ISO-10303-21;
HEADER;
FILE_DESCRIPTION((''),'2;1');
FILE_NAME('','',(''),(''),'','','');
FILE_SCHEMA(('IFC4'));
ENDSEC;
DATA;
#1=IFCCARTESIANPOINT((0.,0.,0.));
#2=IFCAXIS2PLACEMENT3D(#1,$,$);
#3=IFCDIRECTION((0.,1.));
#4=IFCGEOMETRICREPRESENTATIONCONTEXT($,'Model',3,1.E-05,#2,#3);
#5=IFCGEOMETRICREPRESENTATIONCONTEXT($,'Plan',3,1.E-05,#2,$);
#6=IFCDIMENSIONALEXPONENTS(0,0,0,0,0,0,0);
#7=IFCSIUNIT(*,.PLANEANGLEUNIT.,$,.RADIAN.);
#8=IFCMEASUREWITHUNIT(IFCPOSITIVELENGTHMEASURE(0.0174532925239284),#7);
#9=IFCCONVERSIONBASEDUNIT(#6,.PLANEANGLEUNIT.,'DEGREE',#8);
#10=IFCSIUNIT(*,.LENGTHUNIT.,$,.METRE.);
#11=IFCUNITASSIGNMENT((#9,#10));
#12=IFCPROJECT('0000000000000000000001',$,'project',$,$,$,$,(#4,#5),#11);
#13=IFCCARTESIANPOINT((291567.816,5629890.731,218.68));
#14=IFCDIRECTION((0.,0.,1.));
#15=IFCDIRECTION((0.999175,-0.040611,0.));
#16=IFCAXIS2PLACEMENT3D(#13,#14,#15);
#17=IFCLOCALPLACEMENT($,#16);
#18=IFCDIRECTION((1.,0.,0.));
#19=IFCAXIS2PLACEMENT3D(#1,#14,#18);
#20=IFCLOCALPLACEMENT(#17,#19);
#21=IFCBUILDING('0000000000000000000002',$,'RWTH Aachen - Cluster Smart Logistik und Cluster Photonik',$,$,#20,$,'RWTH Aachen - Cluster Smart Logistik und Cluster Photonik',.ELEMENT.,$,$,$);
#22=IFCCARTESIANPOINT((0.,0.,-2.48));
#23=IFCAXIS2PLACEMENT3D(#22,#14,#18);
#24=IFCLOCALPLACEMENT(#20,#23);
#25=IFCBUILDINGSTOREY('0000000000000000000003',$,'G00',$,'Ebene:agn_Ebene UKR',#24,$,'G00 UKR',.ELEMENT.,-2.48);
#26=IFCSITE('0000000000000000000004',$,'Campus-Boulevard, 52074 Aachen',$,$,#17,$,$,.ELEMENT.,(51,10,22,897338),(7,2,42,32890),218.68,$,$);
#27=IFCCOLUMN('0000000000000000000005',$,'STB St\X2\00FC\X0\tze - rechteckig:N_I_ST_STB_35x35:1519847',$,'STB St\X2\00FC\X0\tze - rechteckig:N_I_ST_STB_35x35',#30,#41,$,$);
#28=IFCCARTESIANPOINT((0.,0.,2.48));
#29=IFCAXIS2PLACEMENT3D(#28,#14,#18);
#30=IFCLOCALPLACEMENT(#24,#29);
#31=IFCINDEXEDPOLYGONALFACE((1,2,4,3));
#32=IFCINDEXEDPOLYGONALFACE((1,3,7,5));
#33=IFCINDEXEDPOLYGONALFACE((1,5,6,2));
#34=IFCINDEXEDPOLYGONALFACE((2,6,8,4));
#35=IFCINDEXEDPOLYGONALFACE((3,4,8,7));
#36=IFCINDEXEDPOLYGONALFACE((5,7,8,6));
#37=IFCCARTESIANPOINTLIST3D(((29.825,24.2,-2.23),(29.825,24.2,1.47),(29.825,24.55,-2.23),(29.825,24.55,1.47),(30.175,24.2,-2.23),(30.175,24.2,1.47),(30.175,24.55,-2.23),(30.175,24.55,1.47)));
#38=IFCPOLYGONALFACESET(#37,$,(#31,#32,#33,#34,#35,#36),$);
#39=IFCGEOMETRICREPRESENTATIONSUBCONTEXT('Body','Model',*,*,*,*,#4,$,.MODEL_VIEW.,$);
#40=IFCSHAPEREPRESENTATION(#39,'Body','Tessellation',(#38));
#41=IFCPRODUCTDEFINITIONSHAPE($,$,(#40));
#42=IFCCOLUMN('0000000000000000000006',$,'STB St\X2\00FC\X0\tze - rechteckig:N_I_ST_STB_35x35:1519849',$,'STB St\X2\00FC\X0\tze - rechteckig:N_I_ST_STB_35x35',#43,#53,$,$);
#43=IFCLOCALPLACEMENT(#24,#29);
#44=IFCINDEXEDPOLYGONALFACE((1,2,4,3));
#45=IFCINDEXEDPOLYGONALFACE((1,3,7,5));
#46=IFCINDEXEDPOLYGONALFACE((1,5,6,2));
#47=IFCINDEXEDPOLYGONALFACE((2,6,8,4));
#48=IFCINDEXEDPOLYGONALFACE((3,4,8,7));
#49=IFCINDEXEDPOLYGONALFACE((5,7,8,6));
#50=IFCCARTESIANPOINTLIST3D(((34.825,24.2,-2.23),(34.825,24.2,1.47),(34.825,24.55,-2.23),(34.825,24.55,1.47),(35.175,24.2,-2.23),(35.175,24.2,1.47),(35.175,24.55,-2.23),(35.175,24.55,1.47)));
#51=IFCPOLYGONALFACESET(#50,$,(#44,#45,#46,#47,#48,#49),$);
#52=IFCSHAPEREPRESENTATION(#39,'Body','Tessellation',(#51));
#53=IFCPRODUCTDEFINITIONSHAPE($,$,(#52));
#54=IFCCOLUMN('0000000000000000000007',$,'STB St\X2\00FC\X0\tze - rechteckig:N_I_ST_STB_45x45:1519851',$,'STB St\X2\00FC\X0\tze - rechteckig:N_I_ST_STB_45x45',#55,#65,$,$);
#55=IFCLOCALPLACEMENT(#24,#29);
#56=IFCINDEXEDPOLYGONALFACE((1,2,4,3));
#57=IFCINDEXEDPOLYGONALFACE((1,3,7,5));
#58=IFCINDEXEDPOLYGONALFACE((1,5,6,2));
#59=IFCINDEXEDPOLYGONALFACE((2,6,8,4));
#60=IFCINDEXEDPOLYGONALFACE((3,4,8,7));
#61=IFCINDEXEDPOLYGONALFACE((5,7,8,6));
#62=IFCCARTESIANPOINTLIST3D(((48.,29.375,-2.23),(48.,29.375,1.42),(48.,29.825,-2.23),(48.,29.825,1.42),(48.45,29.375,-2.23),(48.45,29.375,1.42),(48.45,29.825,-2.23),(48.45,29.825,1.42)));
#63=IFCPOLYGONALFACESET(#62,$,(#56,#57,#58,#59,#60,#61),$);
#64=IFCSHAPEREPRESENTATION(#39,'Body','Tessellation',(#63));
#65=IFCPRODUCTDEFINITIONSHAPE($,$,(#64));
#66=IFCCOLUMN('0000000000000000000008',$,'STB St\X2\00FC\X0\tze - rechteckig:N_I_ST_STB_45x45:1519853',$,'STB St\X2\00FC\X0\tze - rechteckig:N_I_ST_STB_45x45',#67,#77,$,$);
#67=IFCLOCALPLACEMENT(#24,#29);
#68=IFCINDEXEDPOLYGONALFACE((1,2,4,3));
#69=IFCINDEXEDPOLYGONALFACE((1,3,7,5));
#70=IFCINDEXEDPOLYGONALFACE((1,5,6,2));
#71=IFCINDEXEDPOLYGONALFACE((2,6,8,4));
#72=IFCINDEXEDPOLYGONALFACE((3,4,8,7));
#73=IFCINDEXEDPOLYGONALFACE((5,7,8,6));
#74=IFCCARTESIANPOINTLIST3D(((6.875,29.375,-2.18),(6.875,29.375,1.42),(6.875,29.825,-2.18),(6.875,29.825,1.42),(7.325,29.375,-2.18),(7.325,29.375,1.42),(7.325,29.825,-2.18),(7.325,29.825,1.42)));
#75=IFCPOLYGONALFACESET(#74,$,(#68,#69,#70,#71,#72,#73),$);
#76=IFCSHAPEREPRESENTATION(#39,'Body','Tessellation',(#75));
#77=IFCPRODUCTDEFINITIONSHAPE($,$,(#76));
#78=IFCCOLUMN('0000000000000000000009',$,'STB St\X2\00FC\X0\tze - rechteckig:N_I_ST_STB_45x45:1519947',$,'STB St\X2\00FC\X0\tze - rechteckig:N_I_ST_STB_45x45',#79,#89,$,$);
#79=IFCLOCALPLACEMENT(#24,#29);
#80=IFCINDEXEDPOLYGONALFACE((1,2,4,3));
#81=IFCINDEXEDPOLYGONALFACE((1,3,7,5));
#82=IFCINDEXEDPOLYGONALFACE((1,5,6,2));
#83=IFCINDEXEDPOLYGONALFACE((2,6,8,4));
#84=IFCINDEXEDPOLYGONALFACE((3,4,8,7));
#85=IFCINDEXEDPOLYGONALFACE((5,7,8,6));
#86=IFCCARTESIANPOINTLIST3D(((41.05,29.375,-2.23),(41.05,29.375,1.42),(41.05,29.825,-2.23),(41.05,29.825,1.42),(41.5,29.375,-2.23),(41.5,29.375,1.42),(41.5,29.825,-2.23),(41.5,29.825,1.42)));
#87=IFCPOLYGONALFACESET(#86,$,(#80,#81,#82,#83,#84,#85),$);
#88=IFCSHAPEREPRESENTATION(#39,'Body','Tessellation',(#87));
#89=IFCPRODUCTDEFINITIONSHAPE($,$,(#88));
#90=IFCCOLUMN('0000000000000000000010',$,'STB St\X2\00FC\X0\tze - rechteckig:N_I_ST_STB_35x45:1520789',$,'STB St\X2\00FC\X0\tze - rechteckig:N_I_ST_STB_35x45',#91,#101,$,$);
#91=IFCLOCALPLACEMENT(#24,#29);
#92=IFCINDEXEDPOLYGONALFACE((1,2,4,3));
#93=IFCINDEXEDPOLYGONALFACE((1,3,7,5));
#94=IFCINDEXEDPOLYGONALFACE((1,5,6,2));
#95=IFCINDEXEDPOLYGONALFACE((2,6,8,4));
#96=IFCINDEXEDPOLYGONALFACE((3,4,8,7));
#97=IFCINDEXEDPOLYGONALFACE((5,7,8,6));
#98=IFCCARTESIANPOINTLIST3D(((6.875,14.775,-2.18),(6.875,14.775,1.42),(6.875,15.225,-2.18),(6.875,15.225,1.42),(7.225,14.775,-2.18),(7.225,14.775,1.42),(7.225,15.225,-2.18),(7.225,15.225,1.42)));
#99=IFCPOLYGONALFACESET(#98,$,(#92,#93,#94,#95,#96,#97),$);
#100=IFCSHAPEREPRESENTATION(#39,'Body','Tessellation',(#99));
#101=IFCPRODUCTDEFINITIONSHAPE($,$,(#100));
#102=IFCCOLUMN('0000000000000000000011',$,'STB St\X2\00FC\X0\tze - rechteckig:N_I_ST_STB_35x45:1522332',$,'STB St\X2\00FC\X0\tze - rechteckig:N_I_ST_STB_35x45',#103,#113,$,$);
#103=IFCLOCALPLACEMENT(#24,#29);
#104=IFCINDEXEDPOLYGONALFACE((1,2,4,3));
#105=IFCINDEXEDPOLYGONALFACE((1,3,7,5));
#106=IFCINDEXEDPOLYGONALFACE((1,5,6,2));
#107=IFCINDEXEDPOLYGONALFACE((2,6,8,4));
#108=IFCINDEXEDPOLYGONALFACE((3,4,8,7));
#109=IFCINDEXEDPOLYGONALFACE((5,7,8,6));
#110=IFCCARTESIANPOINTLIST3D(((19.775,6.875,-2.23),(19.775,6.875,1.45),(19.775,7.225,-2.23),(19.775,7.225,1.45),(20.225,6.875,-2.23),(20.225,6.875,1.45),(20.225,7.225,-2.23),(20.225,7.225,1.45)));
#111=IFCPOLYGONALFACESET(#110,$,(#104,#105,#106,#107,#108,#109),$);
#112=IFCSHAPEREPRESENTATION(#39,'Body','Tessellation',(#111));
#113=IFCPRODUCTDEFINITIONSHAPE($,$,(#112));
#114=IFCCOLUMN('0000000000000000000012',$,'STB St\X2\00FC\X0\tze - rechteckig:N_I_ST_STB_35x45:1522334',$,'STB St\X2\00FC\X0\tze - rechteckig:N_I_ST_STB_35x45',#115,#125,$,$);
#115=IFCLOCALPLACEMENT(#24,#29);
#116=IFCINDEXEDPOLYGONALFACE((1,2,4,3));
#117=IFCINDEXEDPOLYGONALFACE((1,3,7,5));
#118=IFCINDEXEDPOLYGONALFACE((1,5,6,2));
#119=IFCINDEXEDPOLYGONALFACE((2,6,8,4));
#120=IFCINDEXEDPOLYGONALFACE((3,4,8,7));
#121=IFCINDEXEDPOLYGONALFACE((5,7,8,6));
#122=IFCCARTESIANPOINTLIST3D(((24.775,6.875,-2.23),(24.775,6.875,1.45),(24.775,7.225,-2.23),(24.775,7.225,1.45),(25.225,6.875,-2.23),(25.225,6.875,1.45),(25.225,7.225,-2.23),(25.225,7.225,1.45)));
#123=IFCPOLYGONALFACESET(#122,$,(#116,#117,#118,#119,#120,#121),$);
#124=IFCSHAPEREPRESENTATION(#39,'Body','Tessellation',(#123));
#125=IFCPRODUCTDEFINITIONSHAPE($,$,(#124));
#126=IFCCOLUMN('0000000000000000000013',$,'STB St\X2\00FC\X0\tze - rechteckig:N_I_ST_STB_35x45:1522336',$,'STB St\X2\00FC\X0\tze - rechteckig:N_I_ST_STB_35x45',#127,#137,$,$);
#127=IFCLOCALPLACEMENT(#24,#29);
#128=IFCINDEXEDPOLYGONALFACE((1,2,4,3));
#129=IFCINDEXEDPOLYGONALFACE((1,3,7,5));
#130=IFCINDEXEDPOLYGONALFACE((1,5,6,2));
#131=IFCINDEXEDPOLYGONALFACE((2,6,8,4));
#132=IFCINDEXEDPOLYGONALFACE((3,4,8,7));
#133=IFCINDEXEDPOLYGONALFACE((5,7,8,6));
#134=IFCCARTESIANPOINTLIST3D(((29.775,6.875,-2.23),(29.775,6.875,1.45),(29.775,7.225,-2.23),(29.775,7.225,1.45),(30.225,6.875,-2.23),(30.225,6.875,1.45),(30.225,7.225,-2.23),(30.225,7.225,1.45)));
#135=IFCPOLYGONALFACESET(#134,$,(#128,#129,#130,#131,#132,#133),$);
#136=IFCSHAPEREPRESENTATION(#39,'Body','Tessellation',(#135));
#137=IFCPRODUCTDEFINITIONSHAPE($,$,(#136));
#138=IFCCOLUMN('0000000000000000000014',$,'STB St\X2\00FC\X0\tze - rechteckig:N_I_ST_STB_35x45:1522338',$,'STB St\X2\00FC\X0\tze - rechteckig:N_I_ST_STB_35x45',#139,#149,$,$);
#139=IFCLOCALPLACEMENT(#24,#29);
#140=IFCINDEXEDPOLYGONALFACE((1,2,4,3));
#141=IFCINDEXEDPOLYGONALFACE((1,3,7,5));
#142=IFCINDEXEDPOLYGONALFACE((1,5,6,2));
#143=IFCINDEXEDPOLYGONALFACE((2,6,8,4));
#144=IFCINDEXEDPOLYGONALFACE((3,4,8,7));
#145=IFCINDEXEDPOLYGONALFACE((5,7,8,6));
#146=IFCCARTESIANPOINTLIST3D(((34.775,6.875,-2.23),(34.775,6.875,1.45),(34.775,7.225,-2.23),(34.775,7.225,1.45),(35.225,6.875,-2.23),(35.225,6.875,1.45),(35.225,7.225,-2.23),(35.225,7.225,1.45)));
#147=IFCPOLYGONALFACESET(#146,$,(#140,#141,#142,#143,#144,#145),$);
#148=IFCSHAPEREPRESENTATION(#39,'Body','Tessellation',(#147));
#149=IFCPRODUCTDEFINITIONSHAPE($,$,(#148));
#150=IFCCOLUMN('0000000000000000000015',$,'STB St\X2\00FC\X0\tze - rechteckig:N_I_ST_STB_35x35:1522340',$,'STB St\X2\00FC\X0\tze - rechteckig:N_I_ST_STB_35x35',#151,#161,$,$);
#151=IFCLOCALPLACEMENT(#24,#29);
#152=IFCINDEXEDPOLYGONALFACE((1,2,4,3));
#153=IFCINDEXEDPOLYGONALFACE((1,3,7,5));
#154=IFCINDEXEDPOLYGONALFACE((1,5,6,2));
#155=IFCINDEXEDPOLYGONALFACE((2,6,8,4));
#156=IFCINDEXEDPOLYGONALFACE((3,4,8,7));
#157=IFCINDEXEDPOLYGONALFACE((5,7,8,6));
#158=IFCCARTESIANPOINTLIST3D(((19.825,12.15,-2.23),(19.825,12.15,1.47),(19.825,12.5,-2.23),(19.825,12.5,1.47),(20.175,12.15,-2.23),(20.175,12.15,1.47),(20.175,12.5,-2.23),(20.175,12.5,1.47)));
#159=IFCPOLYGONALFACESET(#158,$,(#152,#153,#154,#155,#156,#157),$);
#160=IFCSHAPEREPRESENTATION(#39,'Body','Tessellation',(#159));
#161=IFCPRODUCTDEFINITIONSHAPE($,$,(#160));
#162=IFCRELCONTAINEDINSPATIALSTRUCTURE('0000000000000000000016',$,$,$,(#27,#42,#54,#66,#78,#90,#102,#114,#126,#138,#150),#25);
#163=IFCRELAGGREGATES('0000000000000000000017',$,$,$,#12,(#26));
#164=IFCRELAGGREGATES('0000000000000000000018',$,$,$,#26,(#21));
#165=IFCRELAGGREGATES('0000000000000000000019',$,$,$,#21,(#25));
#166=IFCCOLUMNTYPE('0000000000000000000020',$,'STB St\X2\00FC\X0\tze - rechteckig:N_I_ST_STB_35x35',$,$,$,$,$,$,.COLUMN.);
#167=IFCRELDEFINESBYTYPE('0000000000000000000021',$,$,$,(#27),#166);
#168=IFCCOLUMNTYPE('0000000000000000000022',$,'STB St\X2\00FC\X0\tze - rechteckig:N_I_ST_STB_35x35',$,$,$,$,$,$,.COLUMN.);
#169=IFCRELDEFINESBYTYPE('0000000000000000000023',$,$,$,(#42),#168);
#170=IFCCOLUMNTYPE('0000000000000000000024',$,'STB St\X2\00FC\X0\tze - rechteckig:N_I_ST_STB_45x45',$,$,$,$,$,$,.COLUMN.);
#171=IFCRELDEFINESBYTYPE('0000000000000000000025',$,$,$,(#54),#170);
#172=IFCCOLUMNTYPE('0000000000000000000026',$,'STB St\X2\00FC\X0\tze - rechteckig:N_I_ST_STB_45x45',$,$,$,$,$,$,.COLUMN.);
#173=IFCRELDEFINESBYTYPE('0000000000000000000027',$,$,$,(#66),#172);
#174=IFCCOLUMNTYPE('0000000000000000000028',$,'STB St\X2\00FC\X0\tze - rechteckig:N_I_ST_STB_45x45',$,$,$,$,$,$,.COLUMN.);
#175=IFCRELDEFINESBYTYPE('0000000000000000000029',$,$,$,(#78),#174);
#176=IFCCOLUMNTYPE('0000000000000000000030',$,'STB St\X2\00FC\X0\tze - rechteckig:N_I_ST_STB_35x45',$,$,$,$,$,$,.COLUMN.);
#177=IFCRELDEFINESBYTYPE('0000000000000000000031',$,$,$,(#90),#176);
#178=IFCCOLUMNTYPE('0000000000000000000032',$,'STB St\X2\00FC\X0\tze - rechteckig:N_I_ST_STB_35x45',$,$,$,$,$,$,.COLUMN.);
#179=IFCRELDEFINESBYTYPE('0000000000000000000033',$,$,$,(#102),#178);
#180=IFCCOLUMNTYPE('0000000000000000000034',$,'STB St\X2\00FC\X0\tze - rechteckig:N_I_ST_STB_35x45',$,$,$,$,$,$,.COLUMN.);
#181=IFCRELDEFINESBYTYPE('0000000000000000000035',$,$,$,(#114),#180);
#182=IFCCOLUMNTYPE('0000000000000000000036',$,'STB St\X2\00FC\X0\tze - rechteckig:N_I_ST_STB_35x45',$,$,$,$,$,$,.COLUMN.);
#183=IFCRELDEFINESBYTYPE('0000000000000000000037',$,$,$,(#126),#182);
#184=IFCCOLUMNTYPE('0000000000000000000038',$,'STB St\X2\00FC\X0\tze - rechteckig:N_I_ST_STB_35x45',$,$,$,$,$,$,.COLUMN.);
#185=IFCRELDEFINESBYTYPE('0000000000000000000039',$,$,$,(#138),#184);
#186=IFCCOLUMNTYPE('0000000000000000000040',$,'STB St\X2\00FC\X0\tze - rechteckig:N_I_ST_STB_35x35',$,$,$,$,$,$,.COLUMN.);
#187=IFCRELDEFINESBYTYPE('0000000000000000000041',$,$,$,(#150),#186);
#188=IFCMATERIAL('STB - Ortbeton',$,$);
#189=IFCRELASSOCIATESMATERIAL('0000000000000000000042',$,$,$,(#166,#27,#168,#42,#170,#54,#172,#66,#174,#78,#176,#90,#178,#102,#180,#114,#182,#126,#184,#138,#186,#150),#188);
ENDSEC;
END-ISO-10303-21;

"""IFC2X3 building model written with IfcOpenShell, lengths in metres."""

from ifc_helpers import new_model, entity, si_unit, converted_unit, direction, frame, frame_2d, origin, origin_with_axes, origin_2d_with_axis, place, context, subcontext, project, spatial, rectangle, extrude, source, transform, mapped, material, type_object, element, save


model = new_model("IFC2X3")

# Units and contexts
model_context = context("Model", 3, precision=1e-05, world=origin(), true_north=direction((0.0, 1.0)))
plan_context = context("Plan", 3, precision=1e-05, world=origin())
body_context = subcontext(model_context, "Body", "Model", "MODEL_VIEW")
ifc_project = project(units=[converted_unit("PLANEANGLEUNIT", "DEGREE", entity("IfcPositiveLengthMeasure", 0.0174532925239284), si_unit("PLANEANGLEUNIT", "RADIAN"), dimensions=[0, 0, 0, 0, 0, 0, 0]), si_unit("LENGTHUNIT", "METRE")], contexts=[model_context, plan_context])

# Site, building, storey
site_placement = place(None, frame((291567.816, 5629890.731, 218.68), z_axis=(0.0, 0.0, 1.0), x_axis=(0.999175, -0.040611, 0.0)))
site = spatial("IfcSite", under=ifc_project, at=site_placement, Name="Campus-Boulevard, 52074 Aachen", CompositionType="ELEMENT", RefLatitude=(51, 10, 22, 897338), RefLongitude=(7, 2, 42, 32890), RefElevation=218.68)
building_placement = place(site_placement, origin_with_axes())
building = spatial("IfcBuilding", under=site, at=building_placement, Name="RWTH Aachen - Cluster Smart Logistik und Cluster Photonik", LongName="RWTH Aachen - Cluster Smart Logistik und Cluster Photonik", CompositionType="ELEMENT")
storey_placement = place(building_placement, frame((0.0, 0.0, -2.48), z_axis=(0.0, 0.0, 1.0), x_axis=(1.0, 0.0, 0.0)))
storey = spatial("IfcBuildingStorey", under=building, at=storey_placement, Name="G00", ObjectType="Ebene:agn_Ebene UKR", LongName="G00 UKR", CompositionType="ELEMENT", Elevation=-2.48)

# Shared definitions
ifc_material = material(Name="STB - Ortbeton")

# Columns
column_type_1 = type_object("IfcColumnType", Name="STB Stütze - rechteckig:N_I_ST_STB_35x35", PredefinedType="COLUMN", material=ifc_material)
shared_shape_1 = source(origin(), body_context, "Body", "SweptSolid", [
    extrude(rectangle(XDim=0.35, YDim=0.35, at=origin_2d_with_axis()), frame((30.0, 24.375, -2.23), z_axis=(0.0, 0.0, 1.0), x_axis=(0.0, -1.0, 0.0)), (0.0, 0.0, 1.0), 3.7),
])
column_1_placement = place(storey_placement, frame((0.0, 0.0, 2.48), z_axis=(0.0, 0.0, 1.0), x_axis=(1.0, 0.0, 0.0)))
element("IfcColumn", 1, at=column_1_placement, inside=storey, type_object=column_type_1, material=ifc_material, Name="STB Stütze - rechteckig:N_I_ST_STB_35x35:1519847", ObjectType="STB Stütze - rechteckig:N_I_ST_STB_35x35", context=body_context, shape_type="MappedRepresentation", body=[
    mapped(shared_shape_1, transform((0.0, 0.0, 0.0), scale=1.0)),
])
column_type_2 = type_object("IfcColumnType", Name="STB Stütze - rechteckig:N_I_ST_STB_35x35", PredefinedType="COLUMN", material=ifc_material)
shared_shape_2 = source(origin(), body_context, "Body", "SweptSolid", [
    extrude(rectangle(XDim=0.35, YDim=0.35, at=origin_2d_with_axis()), frame((35.0, 24.375, -2.23), z_axis=(0.0, 0.0, 1.0), x_axis=(0.0, -1.0, 0.0)), (0.0, 0.0, 1.0), 3.7),
])
column_2_placement = place(storey_placement, frame((0.0, 0.0, 2.48), z_axis=(0.0, 0.0, 1.0), x_axis=(1.0, 0.0, 0.0)))
element("IfcColumn", 2, at=column_2_placement, inside=storey, type_object=column_type_2, material=ifc_material, Name="STB Stütze - rechteckig:N_I_ST_STB_35x35:1519849", ObjectType="STB Stütze - rechteckig:N_I_ST_STB_35x35", context=body_context, shape_type="MappedRepresentation", body=[
    mapped(shared_shape_2, transform((0.0, 0.0, 0.0), scale=1.0)),
])
column_type_3 = type_object("IfcColumnType", Name="STB Stütze - rechteckig:N_I_ST_STB_45x45", PredefinedType="COLUMN", material=ifc_material)
shared_shape_3 = source(origin(), body_context, "Body", "SweptSolid", [
    extrude(rectangle(XDim=0.45, YDim=0.45, at=origin_2d_with_axis()), frame((48.225, 29.6, -2.23), z_axis=(0.0, 0.0, 1.0), x_axis=(0.0, -1.0, 0.0)), (0.0, 0.0, 1.0), 3.65),
])
column_3_placement = place(storey_placement, frame((0.0, 0.0, 2.48), z_axis=(0.0, 0.0, 1.0), x_axis=(1.0, 0.0, 0.0)))
element("IfcColumn", 3, at=column_3_placement, inside=storey, type_object=column_type_3, material=ifc_material, Name="STB Stütze - rechteckig:N_I_ST_STB_45x45:1519851", ObjectType="STB Stütze - rechteckig:N_I_ST_STB_45x45", context=body_context, shape_type="MappedRepresentation", body=[
    mapped(shared_shape_3, transform((0.0, 0.0, 0.0), scale=1.0)),
])
column_type_4 = type_object("IfcColumnType", Name="STB Stütze - rechteckig:N_I_ST_STB_45x45", PredefinedType="COLUMN", material=ifc_material)
shared_shape_4 = source(origin(), body_context, "Body", "SweptSolid", [
    extrude(rectangle(XDim=0.45, YDim=0.45, at=origin_2d_with_axis()), frame((7.1, 29.6, -2.18), z_axis=(0.0, 0.0, 1.0), x_axis=(0.0, -1.0, 0.0)), (0.0, 0.0, 1.0), 3.6),
])
column_4_placement = place(storey_placement, frame((0.0, 0.0, 2.48), z_axis=(0.0, 0.0, 1.0), x_axis=(1.0, 0.0, 0.0)))
element("IfcColumn", 4, at=column_4_placement, inside=storey, type_object=column_type_4, material=ifc_material, Name="STB Stütze - rechteckig:N_I_ST_STB_45x45:1519853", ObjectType="STB Stütze - rechteckig:N_I_ST_STB_45x45", context=body_context, shape_type="MappedRepresentation", body=[
    mapped(shared_shape_4, transform((0.0, 0.0, 0.0), scale=1.0)),
])
column_type_5 = type_object("IfcColumnType", Name="STB Stütze - rechteckig:N_I_ST_STB_45x45", PredefinedType="COLUMN", material=ifc_material)
shared_shape_5 = source(origin(), body_context, "Body", "SweptSolid", [
    extrude(rectangle(XDim=0.45, YDim=0.45, at=origin_2d_with_axis()), frame((41.275, 29.6, -2.23), z_axis=(0.0, 0.0, 1.0), x_axis=(0.0, -1.0, 0.0)), (0.0, 0.0, 1.0), 3.65),
])
column_5_placement = place(storey_placement, frame((0.0, 0.0, 2.48), z_axis=(0.0, 0.0, 1.0), x_axis=(1.0, 0.0, 0.0)))
element("IfcColumn", 5, at=column_5_placement, inside=storey, type_object=column_type_5, material=ifc_material, Name="STB Stütze - rechteckig:N_I_ST_STB_45x45:1519947", ObjectType="STB Stütze - rechteckig:N_I_ST_STB_45x45", context=body_context, shape_type="MappedRepresentation", body=[
    mapped(shared_shape_5, transform((0.0, 0.0, 0.0), scale=1.0)),
])
column_type_6 = type_object("IfcColumnType", Name="STB Stütze - rechteckig:N_I_ST_STB_35x45", PredefinedType="COLUMN", material=ifc_material)
shared_shape_6 = source(origin(), body_context, "Body", "SweptSolid", [
    extrude(rectangle(XDim=0.45, YDim=0.35, at=origin_2d_with_axis()), frame((7.05, 15.0, -2.18), z_axis=(0.0, 0.0, 1.0), x_axis=(0.0, -1.0, 0.0)), (0.0, 0.0, 1.0), 3.6),
])
column_6_placement = place(storey_placement, frame((0.0, 0.0, 2.48), z_axis=(0.0, 0.0, 1.0), x_axis=(1.0, 0.0, 0.0)))
element("IfcColumn", 6, at=column_6_placement, inside=storey, type_object=column_type_6, material=ifc_material, Name="STB Stütze - rechteckig:N_I_ST_STB_35x45:1520789", ObjectType="STB Stütze - rechteckig:N_I_ST_STB_35x45", context=body_context, shape_type="MappedRepresentation", body=[
    mapped(shared_shape_6, transform((0.0, 0.0, 0.0), scale=1.0)),
])
column_type_7 = type_object("IfcColumnType", Name="STB Stütze - rechteckig:N_I_ST_STB_35x45", PredefinedType="COLUMN", material=ifc_material)
shared_shape_7 = source(origin(), body_context, "Body", "SweptSolid", [
    extrude(rectangle(XDim=0.35, YDim=0.45, at=origin_2d_with_axis()), frame((20.0, 7.05, -2.23), z_axis=(0.0, 0.0, 1.0), x_axis=(0.0, -1.0, 0.0)), (0.0, 0.0, 1.0), 3.68),
])
column_7_placement = place(storey_placement, frame((0.0, 0.0, 2.48), z_axis=(0.0, 0.0, 1.0), x_axis=(1.0, 0.0, 0.0)))
element("IfcColumn", 7, at=column_7_placement, inside=storey, type_object=column_type_7, material=ifc_material, Name="STB Stütze - rechteckig:N_I_ST_STB_35x45:1522332", ObjectType="STB Stütze - rechteckig:N_I_ST_STB_35x45", context=body_context, shape_type="MappedRepresentation", body=[
    mapped(shared_shape_7, transform((0.0, 0.0, 0.0), scale=1.0)),
])
column_type_8 = type_object("IfcColumnType", Name="STB Stütze - rechteckig:N_I_ST_STB_35x45", PredefinedType="COLUMN", material=ifc_material)
shared_shape_8 = source(origin(), body_context, "Body", "SweptSolid", [
    extrude(rectangle(XDim=0.35, YDim=0.45, at=frame_2d((0.0, 0.0), x_axis=(1.0, 0.0))), frame((25.0, 7.05, -2.23), z_axis=(0.0, 0.0, 1.0), x_axis=(0.0, -1.0, 0.0)), (0.0, 0.0, 1.0), 3.68),
])
column_8_placement = place(storey_placement, frame((0.0, 0.0, 2.48), z_axis=(0.0, 0.0, 1.0), x_axis=(1.0, 0.0, 0.0)))
element("IfcColumn", 8, at=column_8_placement, inside=storey, type_object=column_type_8, material=ifc_material, Name="STB Stütze - rechteckig:N_I_ST_STB_35x45:1522334", ObjectType="STB Stütze - rechteckig:N_I_ST_STB_35x45", context=body_context, shape_type="MappedRepresentation", body=[
    mapped(shared_shape_8, transform((0.0, 0.0, 0.0), scale=1.0)),
])
column_type_9 = type_object("IfcColumnType", Name="STB Stütze - rechteckig:N_I_ST_STB_35x45", PredefinedType="COLUMN", material=ifc_material)
shared_shape_9 = source(origin(), body_context, "Body", "SweptSolid", [
    extrude(rectangle(XDim=0.35, YDim=0.45, at=frame_2d((0.0, 0.0), x_axis=(1.0, 0.0))), frame((30.0, 7.05, -2.23), z_axis=(0.0, 0.0, 1.0), x_axis=(0.0, -1.0, 0.0)), (0.0, 0.0, 1.0), 3.68),
])
column_9_placement = place(storey_placement, frame((0.0, 0.0, 2.48), z_axis=(0.0, 0.0, 1.0), x_axis=(1.0, 0.0, 0.0)))
element("IfcColumn", 9, at=column_9_placement, inside=storey, type_object=column_type_9, material=ifc_material, Name="STB Stütze - rechteckig:N_I_ST_STB_35x45:1522336", ObjectType="STB Stütze - rechteckig:N_I_ST_STB_35x45", context=body_context, shape_type="MappedRepresentation", body=[
    mapped(shared_shape_9, transform((0.0, 0.0, 0.0), scale=1.0)),
])
column_type_10 = type_object("IfcColumnType", Name="STB Stütze - rechteckig:N_I_ST_STB_35x45", PredefinedType="COLUMN", material=ifc_material)
shared_shape_10 = source(origin(), body_context, "Body", "SweptSolid", [
    extrude(rectangle(XDim=0.35, YDim=0.45, at=origin_2d_with_axis()), frame((35.0, 7.05, -2.23), z_axis=(0.0, 0.0, 1.0), x_axis=(0.0, -1.0, 0.0)), (0.0, 0.0, 1.0), 3.68),
])
column_10_placement = place(storey_placement, frame((0.0, 0.0, 2.48), z_axis=(0.0, 0.0, 1.0), x_axis=(1.0, 0.0, 0.0)))
element("IfcColumn", 10, at=column_10_placement, inside=storey, type_object=column_type_10, material=ifc_material, Name="STB Stütze - rechteckig:N_I_ST_STB_35x45:1522338", ObjectType="STB Stütze - rechteckig:N_I_ST_STB_35x45", context=body_context, shape_type="MappedRepresentation", body=[
    mapped(shared_shape_10, transform((0.0, 0.0, 0.0), scale=1.0)),
])
column_type_11 = type_object("IfcColumnType", Name="STB Stütze - rechteckig:N_I_ST_STB_35x35", PredefinedType="COLUMN", material=ifc_material)
shared_shape_11 = source(origin(), body_context, "Body", "SweptSolid", [
    extrude(rectangle(XDim=0.35, YDim=0.35, at=origin_2d_with_axis()), frame((20.0, 12.325, -2.23), z_axis=(0.0, 0.0, 1.0), x_axis=(0.0, -1.0, 0.0)), (0.0, 0.0, 1.0), 3.7),
])
column_11_placement = place(storey_placement, frame((0.0, 0.0, 2.48), z_axis=(0.0, 0.0, 1.0), x_axis=(1.0, 0.0, 0.0)))
element("IfcColumn", 11, at=column_11_placement, inside=storey, type_object=column_type_11, material=ifc_material, Name="STB Stütze - rechteckig:N_I_ST_STB_35x35:1522340", ObjectType="STB Stütze - rechteckig:N_I_ST_STB_35x35", context=body_context, shape_type="MappedRepresentation", body=[
    mapped(shared_shape_11, transform((0.0, 0.0, 0.0), scale=1.0)),
])

save(model, "model.ifc")
